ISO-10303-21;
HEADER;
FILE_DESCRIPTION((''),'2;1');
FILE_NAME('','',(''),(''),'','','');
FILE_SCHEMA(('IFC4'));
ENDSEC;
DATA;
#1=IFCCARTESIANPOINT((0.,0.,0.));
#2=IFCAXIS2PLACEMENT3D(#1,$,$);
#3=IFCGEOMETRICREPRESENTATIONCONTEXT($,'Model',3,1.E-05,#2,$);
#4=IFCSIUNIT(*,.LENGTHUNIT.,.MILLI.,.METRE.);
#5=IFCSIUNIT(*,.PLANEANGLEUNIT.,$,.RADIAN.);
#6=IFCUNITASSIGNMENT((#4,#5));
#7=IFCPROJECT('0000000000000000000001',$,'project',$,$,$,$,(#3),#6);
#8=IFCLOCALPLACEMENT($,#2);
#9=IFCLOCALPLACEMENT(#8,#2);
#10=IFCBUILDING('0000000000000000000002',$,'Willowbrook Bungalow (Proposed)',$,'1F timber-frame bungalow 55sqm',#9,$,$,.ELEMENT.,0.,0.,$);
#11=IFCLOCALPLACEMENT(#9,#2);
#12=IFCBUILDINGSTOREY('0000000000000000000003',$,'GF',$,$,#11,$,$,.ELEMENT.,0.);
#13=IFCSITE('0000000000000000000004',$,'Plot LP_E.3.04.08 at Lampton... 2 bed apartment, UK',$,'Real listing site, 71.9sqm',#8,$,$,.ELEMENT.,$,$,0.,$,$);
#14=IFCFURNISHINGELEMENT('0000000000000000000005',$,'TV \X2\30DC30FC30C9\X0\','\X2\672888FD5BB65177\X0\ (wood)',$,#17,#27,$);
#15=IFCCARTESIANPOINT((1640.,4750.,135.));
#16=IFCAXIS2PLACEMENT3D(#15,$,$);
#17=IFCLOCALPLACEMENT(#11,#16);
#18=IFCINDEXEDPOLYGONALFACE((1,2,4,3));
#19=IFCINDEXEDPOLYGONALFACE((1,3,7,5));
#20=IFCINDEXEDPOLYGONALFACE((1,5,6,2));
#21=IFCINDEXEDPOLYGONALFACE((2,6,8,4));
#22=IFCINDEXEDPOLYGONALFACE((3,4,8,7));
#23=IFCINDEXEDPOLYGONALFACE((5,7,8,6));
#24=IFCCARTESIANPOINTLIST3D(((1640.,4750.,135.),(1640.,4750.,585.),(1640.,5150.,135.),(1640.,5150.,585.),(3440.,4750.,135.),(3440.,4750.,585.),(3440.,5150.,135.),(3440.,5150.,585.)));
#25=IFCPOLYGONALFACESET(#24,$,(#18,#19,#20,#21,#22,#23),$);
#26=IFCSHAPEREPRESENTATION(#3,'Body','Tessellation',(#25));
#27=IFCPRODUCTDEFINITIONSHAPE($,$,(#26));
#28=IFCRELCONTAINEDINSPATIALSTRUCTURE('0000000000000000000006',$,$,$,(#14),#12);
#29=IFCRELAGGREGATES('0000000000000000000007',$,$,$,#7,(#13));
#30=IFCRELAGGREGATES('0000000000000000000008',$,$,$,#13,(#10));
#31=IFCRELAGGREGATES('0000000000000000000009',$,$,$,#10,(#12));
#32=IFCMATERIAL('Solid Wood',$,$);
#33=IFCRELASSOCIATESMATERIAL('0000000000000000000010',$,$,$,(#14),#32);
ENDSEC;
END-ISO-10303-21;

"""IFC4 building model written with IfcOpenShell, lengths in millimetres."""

from ifc_helpers import new_model, si_unit, frame, frame_2d, origin, place, context, project, spatial, rectangle, extrude, material, element, save


model = new_model("IFC4")

# Units and contexts
model_context = context("Model", 3, precision=1e-05, world=origin())
ifc_project = project(units=[si_unit("LENGTHUNIT", "METRE", prefix="MILLI"), si_unit("PLANEANGLEUNIT", "RADIAN")], contexts=[model_context])

# Site, building, storey
site_placement = place(None, origin())
site = spatial("IfcSite", under=ifc_project, at=site_placement, Name="Plot LP_E.3.04.08 at Lampton... 2 bed apartment, UK", ObjectType="Real listing site, 71.9sqm", CompositionType="ELEMENT", RefElevation=0.0)
building_placement = place(site_placement, origin())
building = spatial("IfcBuilding", under=site, at=building_placement, Name="Willowbrook Bungalow (Proposed)", ObjectType="1F timber-frame bungalow 55sqm", CompositionType="ELEMENT", ElevationOfRefHeight=0.0, ElevationOfTerrain=0.0)
storey_placement = place(building_placement, origin())
storey = spatial("IfcBuildingStorey", under=building, at=storey_placement, Name="GF", CompositionType="ELEMENT", Elevation=0.0)

# Shared definitions
ifc_material_1 = material(Name="Solid Wood")

# Furnishing element
furnishing_1_placement = place(storey_placement, frame((1640.0, 4750.0, 135.0)))
element("IfcFurnishingElement", 1, at=furnishing_1_placement, inside=storey, material=ifc_material_1, Name="TV ボード", Description="木製家具 (wood)", context=model_context, shape_type="SweptSolid", body=[
    extrude(rectangle(XDim=1800.0, YDim=400.0, at=frame_2d((900.0, 200.0))), frame((1640.0, 4750.0, 135.0)), (0.0, 0.0, 1.0), 450.0),
])

save(model, "model.ifc")
